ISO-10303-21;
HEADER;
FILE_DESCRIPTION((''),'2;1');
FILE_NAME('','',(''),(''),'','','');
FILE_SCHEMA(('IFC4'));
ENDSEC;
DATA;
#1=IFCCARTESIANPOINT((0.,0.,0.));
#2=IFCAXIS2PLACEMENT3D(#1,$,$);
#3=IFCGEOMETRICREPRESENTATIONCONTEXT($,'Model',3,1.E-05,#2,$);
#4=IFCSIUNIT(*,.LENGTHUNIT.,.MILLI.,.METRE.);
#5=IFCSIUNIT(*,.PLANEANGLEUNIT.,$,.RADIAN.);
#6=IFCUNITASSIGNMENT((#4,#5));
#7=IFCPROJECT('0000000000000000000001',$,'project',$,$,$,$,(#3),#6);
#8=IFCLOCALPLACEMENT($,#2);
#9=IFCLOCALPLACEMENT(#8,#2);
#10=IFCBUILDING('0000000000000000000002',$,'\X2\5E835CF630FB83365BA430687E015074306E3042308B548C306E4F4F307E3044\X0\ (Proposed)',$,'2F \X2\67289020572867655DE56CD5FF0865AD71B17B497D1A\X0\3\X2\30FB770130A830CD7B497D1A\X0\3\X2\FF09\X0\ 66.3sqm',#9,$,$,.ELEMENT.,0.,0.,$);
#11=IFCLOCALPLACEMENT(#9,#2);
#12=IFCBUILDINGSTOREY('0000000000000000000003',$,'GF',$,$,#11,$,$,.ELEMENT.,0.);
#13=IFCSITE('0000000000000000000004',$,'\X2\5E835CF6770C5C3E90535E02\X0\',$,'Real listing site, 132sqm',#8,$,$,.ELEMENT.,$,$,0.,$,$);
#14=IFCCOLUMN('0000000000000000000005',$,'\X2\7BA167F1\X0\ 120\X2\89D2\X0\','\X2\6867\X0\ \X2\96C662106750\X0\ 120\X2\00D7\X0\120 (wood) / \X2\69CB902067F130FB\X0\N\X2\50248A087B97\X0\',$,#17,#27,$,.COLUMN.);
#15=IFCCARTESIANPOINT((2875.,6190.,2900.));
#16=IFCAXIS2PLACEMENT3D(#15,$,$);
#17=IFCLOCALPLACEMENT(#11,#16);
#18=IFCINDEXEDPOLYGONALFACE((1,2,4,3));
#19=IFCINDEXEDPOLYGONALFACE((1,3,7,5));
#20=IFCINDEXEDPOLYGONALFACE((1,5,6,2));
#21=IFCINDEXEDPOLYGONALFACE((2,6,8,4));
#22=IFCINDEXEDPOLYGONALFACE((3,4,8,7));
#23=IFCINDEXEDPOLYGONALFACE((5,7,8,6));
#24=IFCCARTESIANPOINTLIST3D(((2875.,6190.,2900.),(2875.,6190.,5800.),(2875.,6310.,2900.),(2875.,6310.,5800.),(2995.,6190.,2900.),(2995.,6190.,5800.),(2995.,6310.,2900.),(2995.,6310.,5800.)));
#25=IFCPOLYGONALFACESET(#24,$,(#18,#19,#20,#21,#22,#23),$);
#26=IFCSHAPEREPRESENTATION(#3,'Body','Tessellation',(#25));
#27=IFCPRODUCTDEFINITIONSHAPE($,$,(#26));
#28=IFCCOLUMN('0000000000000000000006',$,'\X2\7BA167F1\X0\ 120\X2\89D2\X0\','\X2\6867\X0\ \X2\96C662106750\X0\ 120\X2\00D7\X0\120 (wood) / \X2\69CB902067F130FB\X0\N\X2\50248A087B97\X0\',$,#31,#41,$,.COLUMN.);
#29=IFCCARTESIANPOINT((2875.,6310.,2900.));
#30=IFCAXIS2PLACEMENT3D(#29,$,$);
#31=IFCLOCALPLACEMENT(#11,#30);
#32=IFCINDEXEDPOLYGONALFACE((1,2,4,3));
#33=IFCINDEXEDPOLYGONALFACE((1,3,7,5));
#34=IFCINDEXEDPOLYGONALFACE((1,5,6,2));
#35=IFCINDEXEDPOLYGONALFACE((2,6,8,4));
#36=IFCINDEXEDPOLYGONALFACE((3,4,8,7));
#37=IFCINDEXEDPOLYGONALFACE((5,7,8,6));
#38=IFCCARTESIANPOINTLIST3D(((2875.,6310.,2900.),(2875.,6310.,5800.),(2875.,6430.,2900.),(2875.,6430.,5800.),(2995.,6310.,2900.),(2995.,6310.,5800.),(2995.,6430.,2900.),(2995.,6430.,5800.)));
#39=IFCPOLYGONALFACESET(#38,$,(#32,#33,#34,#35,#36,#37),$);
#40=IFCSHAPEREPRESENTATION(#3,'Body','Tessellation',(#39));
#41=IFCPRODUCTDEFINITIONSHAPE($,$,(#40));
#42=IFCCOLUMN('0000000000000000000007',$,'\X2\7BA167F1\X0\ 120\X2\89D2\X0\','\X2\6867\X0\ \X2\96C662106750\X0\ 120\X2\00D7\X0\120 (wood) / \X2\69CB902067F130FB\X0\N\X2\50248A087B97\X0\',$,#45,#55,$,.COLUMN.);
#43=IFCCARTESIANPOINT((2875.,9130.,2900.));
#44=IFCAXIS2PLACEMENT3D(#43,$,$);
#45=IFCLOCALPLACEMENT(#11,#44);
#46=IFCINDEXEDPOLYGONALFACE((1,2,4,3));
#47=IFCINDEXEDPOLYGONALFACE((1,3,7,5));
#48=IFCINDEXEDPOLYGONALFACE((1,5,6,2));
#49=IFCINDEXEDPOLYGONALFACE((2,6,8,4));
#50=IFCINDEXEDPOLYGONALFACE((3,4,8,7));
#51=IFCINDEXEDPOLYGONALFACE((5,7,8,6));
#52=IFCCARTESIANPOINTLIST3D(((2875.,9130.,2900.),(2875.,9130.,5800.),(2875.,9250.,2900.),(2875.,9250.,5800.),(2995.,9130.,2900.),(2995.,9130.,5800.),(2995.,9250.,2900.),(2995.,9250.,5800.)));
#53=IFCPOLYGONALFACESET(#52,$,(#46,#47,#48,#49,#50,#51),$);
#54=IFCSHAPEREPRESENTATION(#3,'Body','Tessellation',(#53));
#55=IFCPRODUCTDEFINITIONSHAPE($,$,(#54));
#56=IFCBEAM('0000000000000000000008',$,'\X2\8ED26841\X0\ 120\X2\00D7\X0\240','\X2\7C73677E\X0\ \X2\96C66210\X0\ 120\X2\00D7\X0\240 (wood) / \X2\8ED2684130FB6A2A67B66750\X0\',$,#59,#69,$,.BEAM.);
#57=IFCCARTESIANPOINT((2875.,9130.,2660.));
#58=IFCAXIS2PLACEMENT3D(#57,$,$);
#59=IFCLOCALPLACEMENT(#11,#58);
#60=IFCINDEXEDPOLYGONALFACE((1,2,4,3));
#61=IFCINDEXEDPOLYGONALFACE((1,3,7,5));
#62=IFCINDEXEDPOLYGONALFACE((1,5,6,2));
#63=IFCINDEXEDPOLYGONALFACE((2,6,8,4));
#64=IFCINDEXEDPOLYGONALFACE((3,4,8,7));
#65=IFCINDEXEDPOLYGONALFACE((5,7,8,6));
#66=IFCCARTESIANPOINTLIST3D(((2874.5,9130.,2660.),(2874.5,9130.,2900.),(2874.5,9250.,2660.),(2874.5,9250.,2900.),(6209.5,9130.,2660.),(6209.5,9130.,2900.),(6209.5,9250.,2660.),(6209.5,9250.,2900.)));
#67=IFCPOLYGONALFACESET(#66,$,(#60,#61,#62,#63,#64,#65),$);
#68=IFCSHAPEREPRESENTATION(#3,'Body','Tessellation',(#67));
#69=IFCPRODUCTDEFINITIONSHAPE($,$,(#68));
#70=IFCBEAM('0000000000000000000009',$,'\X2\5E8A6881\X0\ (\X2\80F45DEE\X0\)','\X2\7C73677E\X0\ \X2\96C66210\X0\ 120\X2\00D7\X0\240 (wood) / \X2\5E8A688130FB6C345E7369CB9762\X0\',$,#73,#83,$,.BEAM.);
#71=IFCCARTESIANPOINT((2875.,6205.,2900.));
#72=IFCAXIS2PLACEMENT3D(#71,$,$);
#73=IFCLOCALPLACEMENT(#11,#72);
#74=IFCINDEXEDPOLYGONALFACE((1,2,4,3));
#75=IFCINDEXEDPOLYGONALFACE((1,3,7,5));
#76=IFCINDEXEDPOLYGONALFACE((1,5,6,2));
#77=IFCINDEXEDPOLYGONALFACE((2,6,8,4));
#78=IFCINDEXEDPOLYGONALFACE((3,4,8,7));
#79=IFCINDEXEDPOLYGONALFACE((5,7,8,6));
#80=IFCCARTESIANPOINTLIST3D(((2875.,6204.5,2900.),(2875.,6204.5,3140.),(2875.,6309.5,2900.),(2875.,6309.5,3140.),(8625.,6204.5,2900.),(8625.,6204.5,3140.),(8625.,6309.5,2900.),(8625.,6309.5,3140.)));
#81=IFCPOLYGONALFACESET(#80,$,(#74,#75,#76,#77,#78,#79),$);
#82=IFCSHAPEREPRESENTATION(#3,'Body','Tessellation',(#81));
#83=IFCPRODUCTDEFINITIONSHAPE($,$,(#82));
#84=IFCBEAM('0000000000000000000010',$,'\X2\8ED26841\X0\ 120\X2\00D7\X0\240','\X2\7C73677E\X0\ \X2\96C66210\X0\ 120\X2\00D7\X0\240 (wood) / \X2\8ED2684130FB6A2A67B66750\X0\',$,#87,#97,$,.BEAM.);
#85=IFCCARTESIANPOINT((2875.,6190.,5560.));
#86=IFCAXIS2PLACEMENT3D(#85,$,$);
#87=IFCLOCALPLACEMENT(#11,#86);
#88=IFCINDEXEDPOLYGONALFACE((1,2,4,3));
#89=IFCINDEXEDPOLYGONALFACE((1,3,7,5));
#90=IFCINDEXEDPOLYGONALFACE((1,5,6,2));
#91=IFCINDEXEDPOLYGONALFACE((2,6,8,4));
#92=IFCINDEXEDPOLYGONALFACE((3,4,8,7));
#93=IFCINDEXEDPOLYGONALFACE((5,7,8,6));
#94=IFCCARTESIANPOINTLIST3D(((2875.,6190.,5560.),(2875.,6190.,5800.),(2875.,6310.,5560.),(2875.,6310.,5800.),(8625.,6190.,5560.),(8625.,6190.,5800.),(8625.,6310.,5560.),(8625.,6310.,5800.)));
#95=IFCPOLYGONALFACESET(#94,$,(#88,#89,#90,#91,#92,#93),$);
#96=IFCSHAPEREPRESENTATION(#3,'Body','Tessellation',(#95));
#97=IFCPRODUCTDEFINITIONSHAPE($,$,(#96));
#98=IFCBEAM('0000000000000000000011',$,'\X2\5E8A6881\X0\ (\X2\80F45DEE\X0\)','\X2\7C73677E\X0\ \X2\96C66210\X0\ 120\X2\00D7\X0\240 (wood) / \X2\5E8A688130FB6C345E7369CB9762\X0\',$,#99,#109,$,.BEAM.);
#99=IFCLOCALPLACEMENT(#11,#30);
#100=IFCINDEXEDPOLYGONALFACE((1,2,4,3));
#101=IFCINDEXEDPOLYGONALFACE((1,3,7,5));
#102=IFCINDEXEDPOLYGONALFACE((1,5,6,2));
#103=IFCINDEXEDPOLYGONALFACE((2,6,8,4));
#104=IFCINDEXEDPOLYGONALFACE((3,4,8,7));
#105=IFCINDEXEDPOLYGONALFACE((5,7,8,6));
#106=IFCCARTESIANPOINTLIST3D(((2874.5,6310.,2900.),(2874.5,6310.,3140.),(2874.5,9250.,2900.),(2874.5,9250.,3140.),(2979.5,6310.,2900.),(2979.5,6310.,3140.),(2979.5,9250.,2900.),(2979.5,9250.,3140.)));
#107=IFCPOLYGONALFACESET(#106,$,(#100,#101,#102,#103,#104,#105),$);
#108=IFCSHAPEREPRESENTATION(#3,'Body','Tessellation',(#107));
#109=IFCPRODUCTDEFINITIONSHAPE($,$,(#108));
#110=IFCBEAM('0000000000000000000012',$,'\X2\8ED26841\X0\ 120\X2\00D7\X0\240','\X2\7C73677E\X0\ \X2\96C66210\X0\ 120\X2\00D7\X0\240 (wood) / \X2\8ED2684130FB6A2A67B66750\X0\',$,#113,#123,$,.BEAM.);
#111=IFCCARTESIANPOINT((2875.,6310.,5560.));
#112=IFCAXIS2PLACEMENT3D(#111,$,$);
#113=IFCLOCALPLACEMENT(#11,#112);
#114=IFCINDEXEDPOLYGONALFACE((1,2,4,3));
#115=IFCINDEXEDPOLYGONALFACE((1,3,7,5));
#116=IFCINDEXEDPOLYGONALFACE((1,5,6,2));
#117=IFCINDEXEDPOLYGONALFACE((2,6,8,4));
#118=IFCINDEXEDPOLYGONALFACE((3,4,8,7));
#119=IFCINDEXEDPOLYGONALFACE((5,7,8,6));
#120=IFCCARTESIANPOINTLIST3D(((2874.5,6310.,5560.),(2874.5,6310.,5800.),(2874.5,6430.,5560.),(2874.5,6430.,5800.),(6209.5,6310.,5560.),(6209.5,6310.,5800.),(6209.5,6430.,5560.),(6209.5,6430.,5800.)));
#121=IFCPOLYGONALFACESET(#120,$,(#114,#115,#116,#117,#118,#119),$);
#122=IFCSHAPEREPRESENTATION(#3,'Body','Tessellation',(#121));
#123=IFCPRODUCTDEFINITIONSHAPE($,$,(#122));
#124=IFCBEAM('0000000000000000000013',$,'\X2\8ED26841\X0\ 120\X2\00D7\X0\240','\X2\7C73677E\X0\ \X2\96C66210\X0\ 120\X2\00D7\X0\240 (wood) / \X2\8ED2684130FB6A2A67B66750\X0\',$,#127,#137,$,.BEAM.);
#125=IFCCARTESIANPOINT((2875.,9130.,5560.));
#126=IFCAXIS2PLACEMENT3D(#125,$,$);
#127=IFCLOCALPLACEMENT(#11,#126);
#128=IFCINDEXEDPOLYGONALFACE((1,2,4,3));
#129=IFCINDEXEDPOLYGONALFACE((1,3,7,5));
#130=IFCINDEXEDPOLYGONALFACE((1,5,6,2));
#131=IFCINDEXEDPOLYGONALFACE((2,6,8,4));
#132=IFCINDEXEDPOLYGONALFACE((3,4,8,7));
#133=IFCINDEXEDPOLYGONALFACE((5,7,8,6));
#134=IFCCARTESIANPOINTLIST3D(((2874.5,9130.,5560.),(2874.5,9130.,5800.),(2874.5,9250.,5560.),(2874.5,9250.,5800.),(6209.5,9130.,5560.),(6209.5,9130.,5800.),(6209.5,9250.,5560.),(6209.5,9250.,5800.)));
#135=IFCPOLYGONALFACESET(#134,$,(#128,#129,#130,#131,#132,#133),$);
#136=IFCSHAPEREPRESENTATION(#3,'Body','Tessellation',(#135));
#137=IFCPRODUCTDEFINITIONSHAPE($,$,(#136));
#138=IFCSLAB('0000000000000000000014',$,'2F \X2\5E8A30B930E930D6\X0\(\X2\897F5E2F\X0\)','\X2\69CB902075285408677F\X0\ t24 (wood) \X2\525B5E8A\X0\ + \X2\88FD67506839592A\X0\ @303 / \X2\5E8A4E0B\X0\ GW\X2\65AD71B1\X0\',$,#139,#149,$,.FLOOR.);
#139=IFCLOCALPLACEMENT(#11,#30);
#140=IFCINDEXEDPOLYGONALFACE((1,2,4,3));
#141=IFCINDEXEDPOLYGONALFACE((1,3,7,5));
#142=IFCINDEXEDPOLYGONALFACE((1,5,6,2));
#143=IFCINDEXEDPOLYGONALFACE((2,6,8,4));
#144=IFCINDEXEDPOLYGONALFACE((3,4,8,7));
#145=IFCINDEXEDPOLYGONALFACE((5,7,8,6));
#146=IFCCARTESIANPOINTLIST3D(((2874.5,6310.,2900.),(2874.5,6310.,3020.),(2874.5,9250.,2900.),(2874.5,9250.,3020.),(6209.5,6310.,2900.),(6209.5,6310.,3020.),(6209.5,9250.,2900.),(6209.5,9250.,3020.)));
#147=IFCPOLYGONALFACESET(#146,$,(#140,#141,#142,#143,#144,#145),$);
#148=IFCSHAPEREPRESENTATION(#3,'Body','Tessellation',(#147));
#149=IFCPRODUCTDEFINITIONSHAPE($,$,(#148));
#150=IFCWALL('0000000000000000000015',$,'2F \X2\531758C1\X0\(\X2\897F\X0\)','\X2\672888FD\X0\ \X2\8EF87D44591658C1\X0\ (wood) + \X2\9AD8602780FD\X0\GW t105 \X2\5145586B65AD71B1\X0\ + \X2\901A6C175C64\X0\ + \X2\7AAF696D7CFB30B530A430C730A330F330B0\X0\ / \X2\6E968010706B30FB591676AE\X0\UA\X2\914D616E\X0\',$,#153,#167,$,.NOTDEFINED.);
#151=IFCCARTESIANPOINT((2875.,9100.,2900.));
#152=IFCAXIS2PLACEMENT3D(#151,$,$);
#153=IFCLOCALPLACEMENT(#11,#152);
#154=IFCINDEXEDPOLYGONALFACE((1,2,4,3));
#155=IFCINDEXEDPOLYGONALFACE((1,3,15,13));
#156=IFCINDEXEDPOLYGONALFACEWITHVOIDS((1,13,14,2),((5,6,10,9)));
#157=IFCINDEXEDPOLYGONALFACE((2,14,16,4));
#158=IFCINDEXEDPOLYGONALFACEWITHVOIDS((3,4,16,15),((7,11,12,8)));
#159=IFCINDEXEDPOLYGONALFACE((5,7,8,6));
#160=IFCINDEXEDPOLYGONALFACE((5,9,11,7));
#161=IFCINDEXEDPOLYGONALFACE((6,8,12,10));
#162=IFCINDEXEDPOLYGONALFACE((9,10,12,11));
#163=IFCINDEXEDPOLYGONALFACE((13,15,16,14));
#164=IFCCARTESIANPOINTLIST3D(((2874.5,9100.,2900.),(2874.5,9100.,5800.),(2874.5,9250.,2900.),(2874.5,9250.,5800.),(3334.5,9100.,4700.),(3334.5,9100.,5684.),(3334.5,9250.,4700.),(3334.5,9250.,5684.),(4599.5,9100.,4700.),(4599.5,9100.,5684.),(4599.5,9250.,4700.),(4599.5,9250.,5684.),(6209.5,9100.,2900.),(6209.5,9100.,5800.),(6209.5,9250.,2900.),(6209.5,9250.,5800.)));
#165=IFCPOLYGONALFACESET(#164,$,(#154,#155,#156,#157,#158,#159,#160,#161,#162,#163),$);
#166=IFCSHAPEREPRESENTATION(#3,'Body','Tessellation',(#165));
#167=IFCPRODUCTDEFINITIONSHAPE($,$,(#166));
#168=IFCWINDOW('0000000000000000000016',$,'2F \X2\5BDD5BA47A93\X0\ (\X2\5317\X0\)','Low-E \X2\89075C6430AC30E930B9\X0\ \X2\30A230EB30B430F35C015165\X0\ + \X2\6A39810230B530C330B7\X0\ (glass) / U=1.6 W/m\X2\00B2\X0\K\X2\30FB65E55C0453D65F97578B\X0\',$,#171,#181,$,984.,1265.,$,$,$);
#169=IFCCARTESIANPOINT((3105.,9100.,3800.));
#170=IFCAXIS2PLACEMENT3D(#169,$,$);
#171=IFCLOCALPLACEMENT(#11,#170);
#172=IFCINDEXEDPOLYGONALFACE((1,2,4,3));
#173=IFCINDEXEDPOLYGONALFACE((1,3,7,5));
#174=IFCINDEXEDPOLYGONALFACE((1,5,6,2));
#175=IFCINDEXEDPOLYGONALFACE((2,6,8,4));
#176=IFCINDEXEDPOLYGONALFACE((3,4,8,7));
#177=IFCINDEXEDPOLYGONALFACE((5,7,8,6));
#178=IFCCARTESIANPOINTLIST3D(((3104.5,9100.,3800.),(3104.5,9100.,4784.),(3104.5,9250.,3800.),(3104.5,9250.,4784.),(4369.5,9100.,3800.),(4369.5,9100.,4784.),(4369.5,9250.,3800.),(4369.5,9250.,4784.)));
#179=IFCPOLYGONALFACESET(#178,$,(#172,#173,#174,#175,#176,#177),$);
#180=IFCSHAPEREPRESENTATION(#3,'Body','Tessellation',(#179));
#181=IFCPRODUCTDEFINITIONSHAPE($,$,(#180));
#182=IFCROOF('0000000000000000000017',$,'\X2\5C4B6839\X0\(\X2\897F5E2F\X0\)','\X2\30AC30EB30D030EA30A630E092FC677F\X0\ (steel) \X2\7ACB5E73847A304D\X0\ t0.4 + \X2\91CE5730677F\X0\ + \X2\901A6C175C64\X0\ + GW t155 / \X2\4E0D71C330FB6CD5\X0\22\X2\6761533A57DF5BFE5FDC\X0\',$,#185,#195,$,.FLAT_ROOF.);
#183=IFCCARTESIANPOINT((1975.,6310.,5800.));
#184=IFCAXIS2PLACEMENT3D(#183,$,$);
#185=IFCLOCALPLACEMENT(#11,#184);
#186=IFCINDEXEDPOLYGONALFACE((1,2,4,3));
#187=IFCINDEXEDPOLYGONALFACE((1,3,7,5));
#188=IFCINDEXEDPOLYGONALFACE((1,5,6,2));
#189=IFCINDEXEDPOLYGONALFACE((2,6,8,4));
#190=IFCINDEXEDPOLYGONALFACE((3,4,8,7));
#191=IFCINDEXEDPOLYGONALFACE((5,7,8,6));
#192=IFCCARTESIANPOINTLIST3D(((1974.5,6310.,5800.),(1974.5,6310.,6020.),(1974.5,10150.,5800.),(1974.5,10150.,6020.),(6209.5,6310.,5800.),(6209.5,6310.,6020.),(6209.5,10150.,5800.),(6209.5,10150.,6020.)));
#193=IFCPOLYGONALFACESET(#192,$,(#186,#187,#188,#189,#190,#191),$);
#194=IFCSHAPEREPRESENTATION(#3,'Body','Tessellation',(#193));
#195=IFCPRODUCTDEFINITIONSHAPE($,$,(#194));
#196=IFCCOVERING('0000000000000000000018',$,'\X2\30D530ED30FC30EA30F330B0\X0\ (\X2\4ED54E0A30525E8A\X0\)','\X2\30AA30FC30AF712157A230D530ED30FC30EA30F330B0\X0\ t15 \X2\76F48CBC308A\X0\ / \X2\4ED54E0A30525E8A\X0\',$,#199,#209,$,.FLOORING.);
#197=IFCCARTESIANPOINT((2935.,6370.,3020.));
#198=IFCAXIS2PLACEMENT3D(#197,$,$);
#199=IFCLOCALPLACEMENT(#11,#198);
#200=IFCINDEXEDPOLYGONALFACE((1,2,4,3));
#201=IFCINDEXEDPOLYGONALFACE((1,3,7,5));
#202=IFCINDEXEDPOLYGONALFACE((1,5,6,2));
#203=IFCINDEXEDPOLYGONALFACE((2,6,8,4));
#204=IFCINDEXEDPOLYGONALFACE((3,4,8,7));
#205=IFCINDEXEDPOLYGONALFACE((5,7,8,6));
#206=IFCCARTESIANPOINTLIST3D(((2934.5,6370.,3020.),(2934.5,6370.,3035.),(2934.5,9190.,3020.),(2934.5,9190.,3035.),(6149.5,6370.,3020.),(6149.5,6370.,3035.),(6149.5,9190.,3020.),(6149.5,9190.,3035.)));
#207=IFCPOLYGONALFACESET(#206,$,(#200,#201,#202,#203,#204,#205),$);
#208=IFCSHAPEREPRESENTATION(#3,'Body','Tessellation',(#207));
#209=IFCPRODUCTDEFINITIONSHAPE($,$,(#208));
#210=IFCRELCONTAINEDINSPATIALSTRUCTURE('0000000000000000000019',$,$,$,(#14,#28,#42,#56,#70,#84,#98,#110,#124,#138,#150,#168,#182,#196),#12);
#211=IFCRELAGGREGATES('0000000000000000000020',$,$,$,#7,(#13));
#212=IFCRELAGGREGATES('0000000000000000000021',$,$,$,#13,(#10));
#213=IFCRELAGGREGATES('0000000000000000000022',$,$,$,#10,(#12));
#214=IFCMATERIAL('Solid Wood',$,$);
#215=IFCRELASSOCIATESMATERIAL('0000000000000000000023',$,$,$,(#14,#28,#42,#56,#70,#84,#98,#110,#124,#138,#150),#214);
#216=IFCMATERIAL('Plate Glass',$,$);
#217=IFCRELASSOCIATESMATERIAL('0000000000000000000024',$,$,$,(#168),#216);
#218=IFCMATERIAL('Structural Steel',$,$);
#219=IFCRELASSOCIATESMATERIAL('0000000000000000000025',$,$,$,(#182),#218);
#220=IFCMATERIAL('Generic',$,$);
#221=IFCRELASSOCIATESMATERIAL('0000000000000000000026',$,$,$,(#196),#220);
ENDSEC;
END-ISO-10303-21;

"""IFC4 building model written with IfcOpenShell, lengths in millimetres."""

from ifc_helpers import new_model, si_unit, frame, frame_2d, origin, place, context, project, spatial, rectangle, extrude, material, element, fill, save


model = new_model("IFC4")

# Units and contexts
model_context = context("Model", 3, precision=1e-05, world=origin())
ifc_project = project(units=[si_unit("LENGTHUNIT", "METRE", prefix="MILLI"), si_unit("PLANEANGLEUNIT", "RADIAN")], contexts=[model_context])

# Site, building, storey
site_placement = place(None, origin())
site = spatial("IfcSite", under=ifc_project, at=site_placement, Name="広島県尾道市", ObjectType="Real listing site, 132sqm", CompositionType="ELEMENT", RefElevation=0.0)
building_placement = place(site_placement, origin())
building = spatial("IfcBuilding", under=site, at=building_placement, Name="広島・茶室と縁側のある和の住まい (Proposed)", ObjectType="2F 木造在来工法（断熱等級3・省エネ等級3） 66.3sqm", CompositionType="ELEMENT", ElevationOfRefHeight=0.0, ElevationOfTerrain=0.0)
storey_placement = place(building_placement, origin())
storey = spatial("IfcBuildingStorey", under=building, at=storey_placement, Name="GF", CompositionType="ELEMENT", Elevation=0.0)

# Columns
ifc_material_1 = material(Name="Solid Wood")
column_1_placement = place(storey_placement, frame((2875.0, 6190.0, 2900.0)))
element("IfcColumn", 1, at=column_1_placement, inside=storey, material=ifc_material_1, Name="管柱 120角", Description="桧 集成材 120×120 (wood) / 構造柱・N値計算", PredefinedType="COLUMN", context=model_context, shape_type="SweptSolid", body=[
    extrude(rectangle(XDim=120.0, YDim=120.0, at=frame_2d((60.0, 60.0))), frame((2875.0, 6190.0, 2900.0)), (0.0, 0.0, 1.0), 2900.0),
])
column_2_placement = place(storey_placement, frame((2875.0, 6310.0, 2900.0)))
element("IfcColumn", 2, at=column_2_placement, inside=storey, material=ifc_material_1, Name="管柱 120角", Description="桧 集成材 120×120 (wood) / 構造柱・N値計算", PredefinedType="COLUMN", context=model_context, shape_type="SweptSolid", body=[
    extrude(rectangle(XDim=120.0, YDim=120.0, at=frame_2d((60.0, 60.0))), frame((2875.0, 6310.0, 2900.0)), (0.0, 0.0, 1.0), 2900.0),
])
column_3_placement = place(storey_placement, frame((2875.0, 9130.0, 2900.0)))
element("IfcColumn", 3, at=column_3_placement, inside=storey, material=ifc_material_1, Name="管柱 120角", Description="桧 集成材 120×120 (wood) / 構造柱・N値計算", PredefinedType="COLUMN", context=model_context, shape_type="SweptSolid", body=[
    extrude(rectangle(XDim=120.0, YDim=120.0, at=frame_2d((60.0, 60.0))), frame((2875.0, 9130.0, 2900.0)), (0.0, 0.0, 1.0), 2900.0),
])

# Beams
beam_1_placement = place(storey_placement, frame((2875.0, 9130.0, 2660.0)))
element("IfcBeam", 4, at=beam_1_placement, inside=storey, material=ifc_material_1, Name="軒桁 120×240", Description="米松 集成 120×240 (wood) / 軒桁・横架材", PredefinedType="BEAM", context=model_context, shape_type="SweptSolid", body=[
    extrude(rectangle(XDim=3335.0, YDim=120.0, at=frame_2d((1667.0, 60.0))), frame((2875.0, 9130.0, 2660.0)), (0.0, 0.0, 1.0), 240.0),
])
beam_2_placement = place(storey_placement, frame((2875.0, 6205.0, 2900.0)))
element("IfcBeam", 5, at=beam_2_placement, inside=storey, material=ifc_material_1, Name="床梁 (胴差)", Description="米松 集成 120×240 (wood) / 床梁・水平構面", PredefinedType="BEAM", context=model_context, shape_type="SweptSolid", body=[
    extrude(rectangle(XDim=5750.0, YDim=105.0, at=frame_2d((2875.0, 52.0))), frame((2875.0, 6205.0, 2900.0)), (0.0, 0.0, 1.0), 240.0),
])
beam_3_placement = place(storey_placement, frame((2875.0, 6190.0, 5560.0)))
element("IfcBeam", 6, at=beam_3_placement, inside=storey, material=ifc_material_1, Name="軒桁 120×240", Description="米松 集成 120×240 (wood) / 軒桁・横架材", PredefinedType="BEAM", context=model_context, shape_type="SweptSolid", body=[
    extrude(rectangle(XDim=5750.0, YDim=120.0, at=frame_2d((2875.0, 60.0))), frame((2875.0, 6190.0, 5560.0)), (0.0, 0.0, 1.0), 240.0),
])
beam_4_placement = place(storey_placement, frame((2875.0, 6310.0, 2900.0)))
element("IfcBeam", 7, at=beam_4_placement, inside=storey, material=ifc_material_1, Name="床梁 (胴差)", Description="米松 集成 120×240 (wood) / 床梁・水平構面", PredefinedType="BEAM", context=model_context, shape_type="SweptSolid", body=[
    extrude(rectangle(XDim=105.0, YDim=2940.0, at=frame_2d((52.0, 1470.0))), frame((2875.0, 6310.0, 2900.0)), (0.0, 0.0, 1.0), 240.0),
])
beam_5_placement = place(storey_placement, frame((2875.0, 6310.0, 5560.0)))
element("IfcBeam", 8, at=beam_5_placement, inside=storey, material=ifc_material_1, Name="軒桁 120×240", Description="米松 集成 120×240 (wood) / 軒桁・横架材", PredefinedType="BEAM", context=model_context, shape_type="SweptSolid", body=[
    extrude(rectangle(XDim=3335.0, YDim=120.0, at=frame_2d((1667.0, 60.0))), frame((2875.0, 6310.0, 5560.0)), (0.0, 0.0, 1.0), 240.0),
])
beam_6_placement = place(storey_placement, frame((2875.0, 9130.0, 5560.0)))
element("IfcBeam", 9, at=beam_6_placement, inside=storey, material=ifc_material_1, Name="軒桁 120×240", Description="米松 集成 120×240 (wood) / 軒桁・横架材", PredefinedType="BEAM", context=model_context, shape_type="SweptSolid", body=[
    extrude(rectangle(XDim=3335.0, YDim=120.0, at=frame_2d((1667.0, 60.0))), frame((2875.0, 9130.0, 5560.0)), (0.0, 0.0, 1.0), 240.0),
])

# Slab
slab_placement = place(storey_placement, frame((2875.0, 6310.0, 2900.0)))
element("IfcSlab", 10, at=slab_placement, inside=storey, material=ifc_material_1, Name="2F 床スラブ(西帯)", Description="構造用合板 t24 (wood) 剛床 + 製材根太 @303 / 床下 GW断熱", PredefinedType="FLOOR", context=model_context, shape_type="SweptSolid", body=[
    extrude(rectangle(XDim=3335.0, YDim=2940.0, at=frame_2d((1667.0, 1470.0))), frame((2875.0, 6310.0, 2900.0)), (0.0, 0.0, 1.0), 120.0),
])

# Wall, opening, window
wall_1_placement = place(storey_placement, frame((2875.0, 9100.0, 2900.0)))
wall_1 = element("IfcWall", 11, at=wall_1_placement, inside=storey, material=ifc_material_1, Name="2F 北壁(西)", Description="木製 軸組外壁 (wood) + 高性能GW t105 充填断熱 + 通気層 + 窯業系サイディング / 準耐火・外皮UA配慮", PredefinedType="NOTDEFINED", context=model_context, shape_type="SweptSolid", body=[
    extrude(rectangle(XDim=3335.0, YDim=150.0, at=frame_2d((1667.0, 75.0))), frame((2875.0, 9100.0, 2900.0)), (0.0, 0.0, 1.0), 2900.0),
])
opening_placement = place(storey_placement, frame((3105.0, 9100.0, 3800.0)))
opening = element("IfcOpeningElement", 12, at=opening_placement, cuts=wall_1, PredefinedType="NOTDEFINED", context=model_context, shape_type="SweptSolid", body=[
    extrude(rectangle(XDim=1265.0, YDim=150.0, at=frame_2d((632.0, 75.0))), frame((3105.0, 9100.0, 3800.0)), (0.0, 0.0, 1.0), 984.0),
])
ifc_material_2 = material(Name="Plate Glass")
window_placement = place(storey_placement, frame((3105.0, 9100.0, 3800.0)))
window = element("IfcWindow", 13, at=window_placement, inside=storey, material=ifc_material_2, Name="2F 寝室窓 (北)", Description="Low-E 複層ガラス アルゴン封入 + 樹脂サッシ (glass) / U=1.6 W/m²K・日射取得型", OverallHeight=984.0, OverallWidth=1265.0, context=model_context, shape_type="SweptSolid", body=[
    extrude(rectangle(XDim=1265.0, YDim=150.0, at=frame_2d((632.0, 75.0))), frame((3105.0, 9100.0, 3800.0)), (0.0, 0.0, 1.0), 984.0),
])
fill(opening, window)

# Roof
ifc_material_3 = material(Name="Structural Steel")
for number, where, name in (
    (14, (1975.0, 6310.0, 5800.0), "屋根(西帯)"),
):
    element("IfcRoof", number, at=place(storey_placement, frame(where)), inside=storey, material=ifc_material_3, Name=name, Description="ガルバリウム鋼板 (steel) 立平葺き t0.4 + 野地板 + 通気層 + GW t155 / 不燃・法22条区域対応", PredefinedType="FLAT_ROOF", context=model_context, shape_type="SweptSolid", body=[
        extrude(rectangle(XDim=4235.0, YDim=3840.0, at=frame_2d((2117.0, 1920.0))), frame((1975.0, 6310.0, 5800.0)), (0.0, 0.0, 1.0), 220.0),
    ])

# Covering
ifc_material_4 = material(Name="Generic")
covering_placement = place(storey_placement, frame((2935.0, 6370.0, 3020.0)))
element("IfcCovering", 15, at=covering_placement, inside=storey, material=ifc_material_4, Name="フローリング (仕上げ床)", Description="オーク無垢フローリング t15 直貼り / 仕上げ床", PredefinedType="FLOORING", context=model_context, shape_type="SweptSolid", body=[
    extrude(rectangle(XDim=3215.0, YDim=2820.0, at=frame_2d((1607.0, 1410.0))), frame((2935.0, 6370.0, 3020.0)), (0.0, 0.0, 1.0), 15.0),
])

save(model, "model.ifc")
